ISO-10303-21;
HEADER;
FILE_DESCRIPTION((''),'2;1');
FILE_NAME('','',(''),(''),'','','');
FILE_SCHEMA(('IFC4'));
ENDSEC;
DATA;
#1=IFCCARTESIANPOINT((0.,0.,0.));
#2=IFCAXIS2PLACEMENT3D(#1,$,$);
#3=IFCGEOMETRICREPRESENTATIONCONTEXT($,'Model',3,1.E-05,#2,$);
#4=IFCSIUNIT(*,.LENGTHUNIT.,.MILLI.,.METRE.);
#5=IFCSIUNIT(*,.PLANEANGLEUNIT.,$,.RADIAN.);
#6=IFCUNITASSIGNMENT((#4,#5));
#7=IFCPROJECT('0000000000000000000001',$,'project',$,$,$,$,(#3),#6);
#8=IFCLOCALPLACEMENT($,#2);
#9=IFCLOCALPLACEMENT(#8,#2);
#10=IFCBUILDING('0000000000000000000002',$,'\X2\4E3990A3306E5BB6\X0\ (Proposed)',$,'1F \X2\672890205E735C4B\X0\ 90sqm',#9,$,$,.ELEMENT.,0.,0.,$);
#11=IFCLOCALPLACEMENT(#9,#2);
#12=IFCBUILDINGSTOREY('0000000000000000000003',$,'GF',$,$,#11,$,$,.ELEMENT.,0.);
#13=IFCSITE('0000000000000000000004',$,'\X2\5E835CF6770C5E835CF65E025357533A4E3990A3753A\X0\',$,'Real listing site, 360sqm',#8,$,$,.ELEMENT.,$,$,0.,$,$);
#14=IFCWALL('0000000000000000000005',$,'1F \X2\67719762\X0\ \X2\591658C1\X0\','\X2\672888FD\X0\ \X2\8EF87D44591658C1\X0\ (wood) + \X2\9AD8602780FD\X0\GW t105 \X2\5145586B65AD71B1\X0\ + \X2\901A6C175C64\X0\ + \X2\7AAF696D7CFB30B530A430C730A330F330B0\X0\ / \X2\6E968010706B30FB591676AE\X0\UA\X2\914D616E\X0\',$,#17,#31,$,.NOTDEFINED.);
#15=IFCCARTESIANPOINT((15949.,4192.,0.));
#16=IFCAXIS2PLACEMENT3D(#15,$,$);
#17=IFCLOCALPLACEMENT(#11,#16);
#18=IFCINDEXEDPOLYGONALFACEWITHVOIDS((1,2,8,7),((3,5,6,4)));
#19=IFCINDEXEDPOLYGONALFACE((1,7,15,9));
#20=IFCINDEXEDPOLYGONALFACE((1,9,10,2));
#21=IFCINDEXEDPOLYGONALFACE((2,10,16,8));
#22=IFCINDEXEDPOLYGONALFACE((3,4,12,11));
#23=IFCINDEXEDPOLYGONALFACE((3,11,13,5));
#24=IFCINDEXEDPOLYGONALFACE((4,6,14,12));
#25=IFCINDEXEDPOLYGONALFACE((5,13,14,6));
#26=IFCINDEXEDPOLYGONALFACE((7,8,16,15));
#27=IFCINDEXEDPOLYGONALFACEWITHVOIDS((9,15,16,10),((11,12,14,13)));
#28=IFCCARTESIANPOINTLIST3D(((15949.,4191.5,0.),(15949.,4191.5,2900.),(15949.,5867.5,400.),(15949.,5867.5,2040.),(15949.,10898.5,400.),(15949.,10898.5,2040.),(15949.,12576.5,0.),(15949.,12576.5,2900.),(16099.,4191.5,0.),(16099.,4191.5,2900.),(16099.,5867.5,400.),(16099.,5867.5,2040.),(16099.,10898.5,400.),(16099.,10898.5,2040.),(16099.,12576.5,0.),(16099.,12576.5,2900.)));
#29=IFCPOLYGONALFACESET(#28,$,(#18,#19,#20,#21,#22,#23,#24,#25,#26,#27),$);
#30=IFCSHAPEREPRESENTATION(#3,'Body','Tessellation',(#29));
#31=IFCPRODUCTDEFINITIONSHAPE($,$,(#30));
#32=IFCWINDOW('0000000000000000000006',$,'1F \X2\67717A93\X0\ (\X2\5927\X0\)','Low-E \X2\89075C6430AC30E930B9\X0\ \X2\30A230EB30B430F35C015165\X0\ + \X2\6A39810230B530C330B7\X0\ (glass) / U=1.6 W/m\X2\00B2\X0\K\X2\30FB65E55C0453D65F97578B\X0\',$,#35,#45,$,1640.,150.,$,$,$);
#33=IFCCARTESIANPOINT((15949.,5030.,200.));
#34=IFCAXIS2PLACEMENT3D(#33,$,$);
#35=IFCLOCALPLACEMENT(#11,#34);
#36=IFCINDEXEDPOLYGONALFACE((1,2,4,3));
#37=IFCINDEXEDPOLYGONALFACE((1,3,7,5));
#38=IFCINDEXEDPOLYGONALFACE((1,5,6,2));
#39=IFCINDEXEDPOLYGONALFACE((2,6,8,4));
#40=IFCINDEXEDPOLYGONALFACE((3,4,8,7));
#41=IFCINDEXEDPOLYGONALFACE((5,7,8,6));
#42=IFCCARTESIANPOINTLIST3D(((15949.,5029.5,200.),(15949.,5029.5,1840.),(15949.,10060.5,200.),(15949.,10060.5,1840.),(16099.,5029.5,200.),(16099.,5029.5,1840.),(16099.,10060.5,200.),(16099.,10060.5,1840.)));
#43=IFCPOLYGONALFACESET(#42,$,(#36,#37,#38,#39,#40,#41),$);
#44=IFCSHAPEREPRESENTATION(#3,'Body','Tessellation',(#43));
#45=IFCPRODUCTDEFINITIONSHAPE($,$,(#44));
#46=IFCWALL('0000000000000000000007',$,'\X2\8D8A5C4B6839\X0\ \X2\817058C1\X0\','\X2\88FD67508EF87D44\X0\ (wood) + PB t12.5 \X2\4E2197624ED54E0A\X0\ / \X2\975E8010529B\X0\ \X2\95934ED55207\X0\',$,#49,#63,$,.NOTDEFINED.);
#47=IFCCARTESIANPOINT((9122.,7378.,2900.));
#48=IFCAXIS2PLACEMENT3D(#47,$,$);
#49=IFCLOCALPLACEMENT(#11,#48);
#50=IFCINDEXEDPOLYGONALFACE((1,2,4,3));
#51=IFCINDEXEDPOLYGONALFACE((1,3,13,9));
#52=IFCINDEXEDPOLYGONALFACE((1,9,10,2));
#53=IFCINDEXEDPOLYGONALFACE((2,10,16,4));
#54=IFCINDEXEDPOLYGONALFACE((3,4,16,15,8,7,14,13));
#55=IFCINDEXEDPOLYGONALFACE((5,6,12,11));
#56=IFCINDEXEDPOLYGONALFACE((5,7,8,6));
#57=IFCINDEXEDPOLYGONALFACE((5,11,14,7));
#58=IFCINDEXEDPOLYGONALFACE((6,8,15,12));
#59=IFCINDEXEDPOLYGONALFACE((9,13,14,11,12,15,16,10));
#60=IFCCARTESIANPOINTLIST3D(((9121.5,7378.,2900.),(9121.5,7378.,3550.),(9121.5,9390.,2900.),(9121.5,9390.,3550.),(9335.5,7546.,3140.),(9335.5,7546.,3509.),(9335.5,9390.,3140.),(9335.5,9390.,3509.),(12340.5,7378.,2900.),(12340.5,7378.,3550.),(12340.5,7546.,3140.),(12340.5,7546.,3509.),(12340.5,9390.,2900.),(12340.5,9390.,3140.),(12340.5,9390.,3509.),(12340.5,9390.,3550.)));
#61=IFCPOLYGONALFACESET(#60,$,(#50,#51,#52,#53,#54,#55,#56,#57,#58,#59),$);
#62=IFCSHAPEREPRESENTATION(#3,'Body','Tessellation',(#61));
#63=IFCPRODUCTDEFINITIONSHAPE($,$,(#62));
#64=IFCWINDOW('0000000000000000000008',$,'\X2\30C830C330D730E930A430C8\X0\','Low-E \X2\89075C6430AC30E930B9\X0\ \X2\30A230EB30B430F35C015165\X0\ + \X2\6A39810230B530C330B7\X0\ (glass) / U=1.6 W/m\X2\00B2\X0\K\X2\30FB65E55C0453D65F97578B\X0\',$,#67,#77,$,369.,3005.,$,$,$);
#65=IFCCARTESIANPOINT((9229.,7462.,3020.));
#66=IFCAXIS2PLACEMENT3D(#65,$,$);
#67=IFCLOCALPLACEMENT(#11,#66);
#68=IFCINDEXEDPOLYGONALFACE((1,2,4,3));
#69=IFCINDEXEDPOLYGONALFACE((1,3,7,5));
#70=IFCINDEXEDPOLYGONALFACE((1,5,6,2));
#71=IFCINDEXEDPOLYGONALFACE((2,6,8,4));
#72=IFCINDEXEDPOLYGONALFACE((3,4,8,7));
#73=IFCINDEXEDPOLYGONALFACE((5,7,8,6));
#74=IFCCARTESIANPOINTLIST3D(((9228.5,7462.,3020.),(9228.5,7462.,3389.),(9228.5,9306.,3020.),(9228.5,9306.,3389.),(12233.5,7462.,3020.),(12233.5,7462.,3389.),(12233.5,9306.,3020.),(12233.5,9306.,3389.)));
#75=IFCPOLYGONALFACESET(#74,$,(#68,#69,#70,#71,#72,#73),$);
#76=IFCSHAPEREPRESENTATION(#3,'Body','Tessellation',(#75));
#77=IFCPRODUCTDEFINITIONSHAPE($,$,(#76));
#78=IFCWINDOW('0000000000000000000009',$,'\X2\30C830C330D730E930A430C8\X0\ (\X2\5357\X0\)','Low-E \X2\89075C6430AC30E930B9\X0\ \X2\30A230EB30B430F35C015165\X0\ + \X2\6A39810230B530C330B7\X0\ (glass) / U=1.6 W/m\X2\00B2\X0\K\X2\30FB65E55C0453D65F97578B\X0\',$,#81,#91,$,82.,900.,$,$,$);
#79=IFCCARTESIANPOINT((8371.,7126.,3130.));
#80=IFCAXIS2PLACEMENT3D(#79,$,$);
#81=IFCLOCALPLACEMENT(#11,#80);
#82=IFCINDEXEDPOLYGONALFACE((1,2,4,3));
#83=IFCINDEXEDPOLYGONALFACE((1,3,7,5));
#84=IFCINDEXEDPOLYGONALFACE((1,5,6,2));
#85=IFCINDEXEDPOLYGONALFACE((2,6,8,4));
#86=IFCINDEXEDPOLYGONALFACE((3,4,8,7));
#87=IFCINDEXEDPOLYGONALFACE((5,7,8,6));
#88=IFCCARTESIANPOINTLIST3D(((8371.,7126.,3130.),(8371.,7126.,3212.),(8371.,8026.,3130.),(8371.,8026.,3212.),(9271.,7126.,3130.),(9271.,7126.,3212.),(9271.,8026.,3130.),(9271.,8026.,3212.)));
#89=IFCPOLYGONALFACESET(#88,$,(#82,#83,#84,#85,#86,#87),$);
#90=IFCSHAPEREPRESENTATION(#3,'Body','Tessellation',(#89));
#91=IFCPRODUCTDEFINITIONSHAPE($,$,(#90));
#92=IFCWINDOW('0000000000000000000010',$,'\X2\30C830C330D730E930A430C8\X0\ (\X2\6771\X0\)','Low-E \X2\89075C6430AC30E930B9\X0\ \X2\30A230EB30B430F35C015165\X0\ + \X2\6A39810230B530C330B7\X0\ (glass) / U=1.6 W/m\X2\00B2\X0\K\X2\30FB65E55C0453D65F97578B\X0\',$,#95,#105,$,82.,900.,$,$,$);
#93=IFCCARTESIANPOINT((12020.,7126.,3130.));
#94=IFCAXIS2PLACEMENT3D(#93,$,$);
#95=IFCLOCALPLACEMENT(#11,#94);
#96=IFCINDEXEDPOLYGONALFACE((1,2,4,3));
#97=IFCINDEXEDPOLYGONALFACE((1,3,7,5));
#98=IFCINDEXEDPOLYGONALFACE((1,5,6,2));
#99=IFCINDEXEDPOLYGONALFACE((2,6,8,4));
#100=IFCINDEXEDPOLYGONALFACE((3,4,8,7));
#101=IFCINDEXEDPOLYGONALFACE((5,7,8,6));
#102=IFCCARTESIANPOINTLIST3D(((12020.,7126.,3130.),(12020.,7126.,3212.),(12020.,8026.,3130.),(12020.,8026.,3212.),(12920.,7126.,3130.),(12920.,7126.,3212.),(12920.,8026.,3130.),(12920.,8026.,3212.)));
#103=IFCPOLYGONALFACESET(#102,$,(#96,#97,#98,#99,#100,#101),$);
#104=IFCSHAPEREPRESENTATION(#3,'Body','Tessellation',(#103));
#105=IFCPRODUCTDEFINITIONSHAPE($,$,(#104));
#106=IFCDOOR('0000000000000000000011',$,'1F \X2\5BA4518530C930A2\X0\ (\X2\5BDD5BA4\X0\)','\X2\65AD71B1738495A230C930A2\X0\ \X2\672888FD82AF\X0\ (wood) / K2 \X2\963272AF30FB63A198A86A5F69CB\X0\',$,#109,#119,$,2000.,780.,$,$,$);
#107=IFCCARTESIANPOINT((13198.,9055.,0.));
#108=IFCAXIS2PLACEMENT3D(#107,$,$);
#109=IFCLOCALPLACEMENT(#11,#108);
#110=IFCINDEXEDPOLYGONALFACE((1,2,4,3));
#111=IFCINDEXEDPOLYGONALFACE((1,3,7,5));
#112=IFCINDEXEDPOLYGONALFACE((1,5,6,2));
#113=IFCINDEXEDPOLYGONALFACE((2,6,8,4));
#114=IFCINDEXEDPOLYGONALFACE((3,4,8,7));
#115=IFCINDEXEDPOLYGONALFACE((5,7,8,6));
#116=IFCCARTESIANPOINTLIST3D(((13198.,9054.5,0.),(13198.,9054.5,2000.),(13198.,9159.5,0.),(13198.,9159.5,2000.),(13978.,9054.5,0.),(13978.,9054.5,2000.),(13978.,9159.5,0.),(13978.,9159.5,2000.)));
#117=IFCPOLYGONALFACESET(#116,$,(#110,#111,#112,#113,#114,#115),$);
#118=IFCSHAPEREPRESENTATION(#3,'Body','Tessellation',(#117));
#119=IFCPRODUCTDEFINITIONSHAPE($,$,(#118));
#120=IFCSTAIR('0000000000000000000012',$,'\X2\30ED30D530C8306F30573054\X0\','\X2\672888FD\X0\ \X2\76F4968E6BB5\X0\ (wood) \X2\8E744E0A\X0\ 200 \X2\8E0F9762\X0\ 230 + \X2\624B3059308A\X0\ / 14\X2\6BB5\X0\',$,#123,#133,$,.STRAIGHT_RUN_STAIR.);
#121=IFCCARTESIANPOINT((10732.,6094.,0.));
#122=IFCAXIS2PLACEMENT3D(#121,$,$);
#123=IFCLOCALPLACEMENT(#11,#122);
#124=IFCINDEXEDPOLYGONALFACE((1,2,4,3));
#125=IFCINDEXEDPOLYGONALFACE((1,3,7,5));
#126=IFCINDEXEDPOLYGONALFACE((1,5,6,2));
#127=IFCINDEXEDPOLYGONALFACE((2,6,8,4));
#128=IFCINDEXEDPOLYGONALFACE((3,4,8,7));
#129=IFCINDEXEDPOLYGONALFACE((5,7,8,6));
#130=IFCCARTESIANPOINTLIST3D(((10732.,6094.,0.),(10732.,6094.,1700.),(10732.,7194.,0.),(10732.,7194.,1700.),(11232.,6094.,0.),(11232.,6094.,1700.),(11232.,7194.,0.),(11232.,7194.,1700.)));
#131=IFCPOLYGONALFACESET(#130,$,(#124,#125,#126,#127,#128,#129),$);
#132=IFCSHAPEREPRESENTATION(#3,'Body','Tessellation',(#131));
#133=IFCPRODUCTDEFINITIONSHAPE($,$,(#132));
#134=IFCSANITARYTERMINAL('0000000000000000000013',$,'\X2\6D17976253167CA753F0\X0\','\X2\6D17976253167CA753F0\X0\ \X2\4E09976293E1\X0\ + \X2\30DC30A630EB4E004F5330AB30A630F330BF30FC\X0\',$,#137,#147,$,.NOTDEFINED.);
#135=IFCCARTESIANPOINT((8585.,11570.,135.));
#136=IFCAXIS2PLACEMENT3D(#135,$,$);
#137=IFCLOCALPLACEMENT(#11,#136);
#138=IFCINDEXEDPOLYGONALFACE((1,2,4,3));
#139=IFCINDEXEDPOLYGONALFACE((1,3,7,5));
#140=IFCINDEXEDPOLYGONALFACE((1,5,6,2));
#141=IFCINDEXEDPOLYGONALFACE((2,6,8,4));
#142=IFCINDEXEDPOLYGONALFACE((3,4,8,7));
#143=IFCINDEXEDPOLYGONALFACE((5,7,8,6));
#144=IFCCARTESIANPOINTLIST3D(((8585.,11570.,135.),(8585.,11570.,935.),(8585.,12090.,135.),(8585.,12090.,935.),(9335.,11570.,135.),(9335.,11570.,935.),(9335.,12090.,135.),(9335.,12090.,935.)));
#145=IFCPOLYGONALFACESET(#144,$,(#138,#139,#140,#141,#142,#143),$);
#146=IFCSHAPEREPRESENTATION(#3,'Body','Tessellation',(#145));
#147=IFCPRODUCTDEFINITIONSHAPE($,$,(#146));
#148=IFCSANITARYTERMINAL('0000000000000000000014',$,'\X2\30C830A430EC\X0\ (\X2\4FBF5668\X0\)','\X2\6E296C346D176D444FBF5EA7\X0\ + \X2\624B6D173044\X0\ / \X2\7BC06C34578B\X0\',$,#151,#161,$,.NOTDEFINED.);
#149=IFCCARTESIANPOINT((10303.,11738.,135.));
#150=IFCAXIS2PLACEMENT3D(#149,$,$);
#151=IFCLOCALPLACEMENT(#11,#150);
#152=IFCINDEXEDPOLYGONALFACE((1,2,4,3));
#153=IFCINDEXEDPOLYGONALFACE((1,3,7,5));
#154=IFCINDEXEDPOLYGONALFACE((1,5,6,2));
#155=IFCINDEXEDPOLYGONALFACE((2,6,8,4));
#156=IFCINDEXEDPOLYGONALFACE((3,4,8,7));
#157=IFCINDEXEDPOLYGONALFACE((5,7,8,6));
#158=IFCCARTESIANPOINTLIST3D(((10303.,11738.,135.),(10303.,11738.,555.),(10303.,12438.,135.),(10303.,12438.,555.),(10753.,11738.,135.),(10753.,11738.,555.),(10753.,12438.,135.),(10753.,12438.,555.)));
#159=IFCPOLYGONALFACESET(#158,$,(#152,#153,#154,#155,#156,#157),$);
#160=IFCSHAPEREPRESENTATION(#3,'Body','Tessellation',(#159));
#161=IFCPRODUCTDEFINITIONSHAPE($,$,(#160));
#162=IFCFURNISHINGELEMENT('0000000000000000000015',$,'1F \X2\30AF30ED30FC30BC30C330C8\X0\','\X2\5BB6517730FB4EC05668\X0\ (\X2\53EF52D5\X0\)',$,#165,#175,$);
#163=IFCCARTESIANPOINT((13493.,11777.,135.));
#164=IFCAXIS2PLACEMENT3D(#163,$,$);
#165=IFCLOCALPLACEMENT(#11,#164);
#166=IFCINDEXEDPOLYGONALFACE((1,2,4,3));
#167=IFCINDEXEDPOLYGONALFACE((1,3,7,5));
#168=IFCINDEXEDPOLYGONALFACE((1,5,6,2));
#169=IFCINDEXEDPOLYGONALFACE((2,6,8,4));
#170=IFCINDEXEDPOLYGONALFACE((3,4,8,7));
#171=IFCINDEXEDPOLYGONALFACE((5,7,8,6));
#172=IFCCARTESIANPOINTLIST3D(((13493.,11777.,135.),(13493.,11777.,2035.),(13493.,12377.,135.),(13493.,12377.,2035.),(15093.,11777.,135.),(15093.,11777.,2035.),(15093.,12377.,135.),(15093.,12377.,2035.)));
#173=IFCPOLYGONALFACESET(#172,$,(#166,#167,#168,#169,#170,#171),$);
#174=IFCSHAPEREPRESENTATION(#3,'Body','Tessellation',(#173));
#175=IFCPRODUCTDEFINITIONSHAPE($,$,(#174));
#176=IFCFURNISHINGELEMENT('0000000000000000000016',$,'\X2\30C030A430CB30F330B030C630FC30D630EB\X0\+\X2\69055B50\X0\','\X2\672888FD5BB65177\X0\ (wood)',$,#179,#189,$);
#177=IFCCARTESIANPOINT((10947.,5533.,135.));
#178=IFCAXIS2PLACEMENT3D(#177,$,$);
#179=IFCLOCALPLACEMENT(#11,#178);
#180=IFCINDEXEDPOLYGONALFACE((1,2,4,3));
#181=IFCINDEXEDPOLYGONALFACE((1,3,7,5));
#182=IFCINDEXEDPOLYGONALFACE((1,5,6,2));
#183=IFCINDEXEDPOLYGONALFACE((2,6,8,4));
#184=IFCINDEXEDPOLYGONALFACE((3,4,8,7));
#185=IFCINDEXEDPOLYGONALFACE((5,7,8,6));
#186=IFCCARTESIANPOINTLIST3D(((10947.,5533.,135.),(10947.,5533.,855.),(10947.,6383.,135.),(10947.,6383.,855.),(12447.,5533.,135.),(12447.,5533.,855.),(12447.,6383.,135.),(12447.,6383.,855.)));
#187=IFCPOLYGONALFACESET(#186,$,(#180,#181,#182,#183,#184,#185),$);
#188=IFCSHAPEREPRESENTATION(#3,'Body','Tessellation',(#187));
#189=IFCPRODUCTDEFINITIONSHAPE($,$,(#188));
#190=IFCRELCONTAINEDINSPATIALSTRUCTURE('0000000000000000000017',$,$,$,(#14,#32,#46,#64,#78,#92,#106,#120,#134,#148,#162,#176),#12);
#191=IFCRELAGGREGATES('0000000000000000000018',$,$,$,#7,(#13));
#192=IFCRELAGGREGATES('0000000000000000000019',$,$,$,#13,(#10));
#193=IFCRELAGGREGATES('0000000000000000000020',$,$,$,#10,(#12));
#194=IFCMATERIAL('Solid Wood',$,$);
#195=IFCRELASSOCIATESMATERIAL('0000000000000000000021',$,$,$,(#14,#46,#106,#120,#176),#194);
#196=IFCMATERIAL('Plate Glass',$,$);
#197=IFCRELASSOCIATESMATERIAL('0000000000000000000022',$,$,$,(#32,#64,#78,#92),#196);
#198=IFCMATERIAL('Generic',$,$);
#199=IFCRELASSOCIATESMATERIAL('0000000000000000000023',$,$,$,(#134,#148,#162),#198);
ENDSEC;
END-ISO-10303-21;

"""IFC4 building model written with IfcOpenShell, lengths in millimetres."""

from ifc_helpers import new_model, si_unit, frame, frame_2d, origin, place, context, project, spatial, rectangle, extrude, material, element, fill, save


model = new_model("IFC4")

# Units and contexts
model_context = context("Model", 3, precision=1e-05, world=origin())
ifc_project = project(units=[si_unit("LENGTHUNIT", "METRE", prefix="MILLI"), si_unit("PLANEANGLEUNIT", "RADIAN")], contexts=[model_context])

# Site, building, storey
site_placement = place(None, origin())
site = spatial("IfcSite", under=ifc_project, at=site_placement, Name="広島県広島市南区丹那町", ObjectType="Real listing site, 360sqm", CompositionType="ELEMENT", RefElevation=0.0)
building_placement = place(site_placement, origin())
building = spatial("IfcBuilding", under=site, at=building_placement, Name="丹那の家 (Proposed)", ObjectType="1F 木造平屋 90sqm", CompositionType="ELEMENT", ElevationOfRefHeight=0.0, ElevationOfTerrain=0.0)
storey_placement = place(building_placement, origin())
storey = spatial("IfcBuildingStorey", under=building, at=storey_placement, Name="GF", CompositionType="ELEMENT", Elevation=0.0)

# Wall, opening, window
ifc_material_1 = material(Name="Solid Wood")
wall_1_placement = place(storey_placement, frame((15949.0, 4192.0, 0.0)))
wall_1 = element("IfcWall", 1, at=wall_1_placement, inside=storey, material=ifc_material_1, Name="1F 東面 外壁", Description="木製 軸組外壁 (wood) + 高性能GW t105 充填断熱 + 通気層 + 窯業系サイディング / 準耐火・外皮UA配慮", PredefinedType="NOTDEFINED", context=model_context, shape_type="SweptSolid", body=[
    extrude(rectangle(XDim=150.0, YDim=8385.0, at=frame_2d((75.0, 4192.0))), frame((15949.0, 4192.0, 0.0)), (0.0, 0.0, 1.0), 2900.0),
])
opening_1_placement = place(storey_placement, frame((15949.0, 5030.0, 200.0)))
opening_1 = element("IfcOpeningElement", 2, at=opening_1_placement, cuts=wall_1, PredefinedType="NOTDEFINED", context=model_context, shape_type="SweptSolid", body=[
    extrude(rectangle(XDim=150.0, YDim=5031.0, at=frame_2d((75.0, 2515.0))), frame((15949.0, 5030.0, 200.0)), (0.0, 0.0, 1.0), 1640.0),
])
ifc_material_2 = material(Name="Plate Glass")
window_1_placement = place(storey_placement, frame((15949.0, 5030.0, 200.0)))
window_1 = element("IfcWindow", 3, at=window_1_placement, inside=storey, material=ifc_material_2, Name="1F 東窓 (大)", Description="Low-E 複層ガラス アルゴン封入 + 樹脂サッシ (glass) / U=1.6 W/m²K・日射取得型", OverallHeight=1640.0, OverallWidth=150.0, context=model_context, shape_type="SweptSolid", body=[
    extrude(rectangle(XDim=150.0, YDim=5031.0, at=frame_2d((75.0, 2515.0))), frame((15949.0, 5030.0, 200.0)), (0.0, 0.0, 1.0), 1640.0),
])
fill(opening_1, window_1)

# Wall, openings, windows
wall_2_placement = place(storey_placement, frame((9122.0, 7378.0, 2900.0)))
wall_2 = element("IfcWall", 4, at=wall_2_placement, inside=storey, material=ifc_material_1, Name="越屋根 腰壁", Description="製材軸組 (wood) + PB t12.5 両面仕上 / 非耐力 間仕切", PredefinedType="NOTDEFINED", context=model_context, shape_type="SweptSolid", body=[
    extrude(rectangle(XDim=3219.0, YDim=2012.0, at=frame_2d((1609.0, 1006.0))), frame((9122.0, 7378.0, 2900.0)), (0.0, 0.0, 1.0), 650.0),
])
opening_2_placement = place(storey_placement, frame((9229.0, 7462.0, 3020.0)))
opening_2 = element("IfcOpeningElement", 5, at=opening_2_placement, cuts=wall_2, PredefinedType="NOTDEFINED", context=model_context, shape_type="SweptSolid", body=[
    extrude(rectangle(XDim=3005.0, YDim=1844.0, at=frame_2d((1502.0, 922.0))), frame((9229.0, 7462.0, 3020.0)), (0.0, 0.0, 1.0), 369.0),
])
opening_3_placement = place(storey_placement, frame((8371.0, 7126.0, 3130.0)))
opening_3 = element("IfcOpeningElement", 6, at=opening_3_placement, cuts=wall_2, PredefinedType="NOTDEFINED", context=model_context, shape_type="SweptSolid", body=[
    extrude(rectangle(XDim=900.0, YDim=900.0, at=frame_2d((450.0, 450.0))), frame((8371.0, 7126.0, 3130.0)), (0.0, 0.0, 1.0), 82.0),
])
opening_4_placement = place(storey_placement, frame((12020.0, 7126.0, 3130.0)))
opening_4 = element("IfcOpeningElement", 7, at=opening_4_placement, cuts=wall_2, PredefinedType="NOTDEFINED", context=model_context, shape_type="SweptSolid", body=[
    extrude(rectangle(XDim=900.0, YDim=900.0, at=frame_2d((450.0, 450.0))), frame((12020.0, 7126.0, 3130.0)), (0.0, 0.0, 1.0), 82.0),
])
window_2_placement = place(storey_placement, frame((9229.0, 7462.0, 3020.0)))
window_2 = element("IfcWindow", 8, at=window_2_placement, inside=storey, material=ifc_material_2, Name="トップライト", Description="Low-E 複層ガラス アルゴン封入 + 樹脂サッシ (glass) / U=1.6 W/m²K・日射取得型", OverallHeight=369.0, OverallWidth=3005.0, context=model_context, shape_type="SweptSolid", body=[
    extrude(rectangle(XDim=3005.0, YDim=1844.0, at=frame_2d((1502.0, 922.0))), frame((9229.0, 7462.0, 3020.0)), (0.0, 0.0, 1.0), 369.0),
])
fill(opening_2, window_2)
window_3_placement = place(storey_placement, frame((8371.0, 7126.0, 3130.0)))
window_3 = element("IfcWindow", 9, at=window_3_placement, inside=storey, material=ifc_material_2, Name="トップライト (南)", Description="Low-E 複層ガラス アルゴン封入 + 樹脂サッシ (glass) / U=1.6 W/m²K・日射取得型", OverallHeight=82.0, OverallWidth=900.0, context=model_context, shape_type="SweptSolid", body=[
    extrude(rectangle(XDim=900.0, YDim=900.0, at=frame_2d((450.0, 450.0))), frame((8371.0, 7126.0, 3130.0)), (0.0, 0.0, 1.0), 82.0),
])
fill(opening_3, window_3)
window_4_placement = place(storey_placement, frame((12020.0, 7126.0, 3130.0)))
window_4 = element("IfcWindow", 10, at=window_4_placement, inside=storey, material=ifc_material_2, Name="トップライト (東)", Description="Low-E 複層ガラス アルゴン封入 + 樹脂サッシ (glass) / U=1.6 W/m²K・日射取得型", OverallHeight=82.0, OverallWidth=900.0, context=model_context, shape_type="SweptSolid", body=[
    extrude(rectangle(XDim=900.0, YDim=900.0, at=frame_2d((450.0, 450.0))), frame((12020.0, 7126.0, 3130.0)), (0.0, 0.0, 1.0), 82.0),
])
fill(opening_4, window_4)

# Door
door_placement = place(storey_placement, frame((13198.0, 9055.0, 0.0)))
element("IfcDoor", 11, at=door_placement, inside=storey, material=ifc_material_1, Name="1F 室内ドア (寝室)", Description="断熱玄関ドア 木製芯 (wood) / K2 防犯・採風機構", OverallHeight=2000.0, OverallWidth=780.0, context=model_context, shape_type="SweptSolid", body=[
    extrude(rectangle(XDim=780.0, YDim=105.0, at=frame_2d((390.0, 52.0))), frame((13198.0, 9055.0, 0.0)), (0.0, 0.0, 1.0), 2000.0),
])

# Stair
stair_placement = place(storey_placement, frame((10732.0, 6094.0, 0.0)))
element("IfcStair", 12, at=stair_placement, inside=storey, material=ifc_material_1, Name="ロフトはしご", Description="木製 直階段 (wood) 蹴上 200 踏面 230 + 手すり / 14段", PredefinedType="STRAIGHT_RUN_STAIR", context=model_context, shape_type="SweptSolid", body=[
    extrude(rectangle(XDim=500.0, YDim=1100.0, at=frame_2d((250.0, 550.0))), frame((10732.0, 6094.0, 0.0)), (0.0, 0.0, 1.0), 1700.0),
])

# Sanitary terminals
ifc_material_3 = material(Name="Generic")
sanitary_terminal_1_placement = place(storey_placement, frame((8585.0, 11570.0, 135.0)))
element("IfcSanitaryTerminal", 13, at=sanitary_terminal_1_placement, inside=storey, material=ifc_material_3, Name="洗面化粧台", Description="洗面化粧台 三面鏡 + ボウル一体カウンター", PredefinedType="NOTDEFINED", context=model_context, shape_type="SweptSolid", body=[
    extrude(rectangle(XDim=750.0, YDim=520.0, at=frame_2d((375.0, 260.0))), frame((8585.0, 11570.0, 135.0)), (0.0, 0.0, 1.0), 800.0),
])
sanitary_terminal_2_placement = place(storey_placement, frame((10303.0, 11738.0, 135.0)))
element("IfcSanitaryTerminal", 14, at=sanitary_terminal_2_placement, inside=storey, material=ifc_material_3, Name="トイレ (便器)", Description="温水洗浄便座 + 手洗い / 節水型", PredefinedType="NOTDEFINED", context=model_context, shape_type="SweptSolid", body=[
    extrude(rectangle(XDim=450.0, YDim=700.0, at=frame_2d((225.0, 350.0))), frame((10303.0, 11738.0, 135.0)), (0.0, 0.0, 1.0), 420.0),
])

# Furnishing elements
furnishing_1_placement = place(storey_placement, frame((13493.0, 11777.0, 135.0)))
element("IfcFurnishingElement", 15, at=furnishing_1_placement, inside=storey, material=ifc_material_3, Name="1F クローゼット", Description="家具・什器 (可動)", context=model_context, shape_type="SweptSolid", body=[
    extrude(rectangle(XDim=1600.0, YDim=600.0, at=frame_2d((800.0, 300.0))), frame((13493.0, 11777.0, 135.0)), (0.0, 0.0, 1.0), 1900.0),
])
furnishing_2_placement = place(storey_placement, frame((10947.0, 5533.0, 135.0)))
element("IfcFurnishingElement", 16, at=furnishing_2_placement, inside=storey, material=ifc_material_1, Name="ダイニングテーブル+椅子", Description="木製家具 (wood)", context=model_context, shape_type="SweptSolid", body=[
    extrude(rectangle(XDim=1500.0, YDim=850.0, at=frame_2d((750.0, 425.0))), frame((10947.0, 5533.0, 135.0)), (0.0, 0.0, 1.0), 720.0),
])

save(model, "model.ifc")
